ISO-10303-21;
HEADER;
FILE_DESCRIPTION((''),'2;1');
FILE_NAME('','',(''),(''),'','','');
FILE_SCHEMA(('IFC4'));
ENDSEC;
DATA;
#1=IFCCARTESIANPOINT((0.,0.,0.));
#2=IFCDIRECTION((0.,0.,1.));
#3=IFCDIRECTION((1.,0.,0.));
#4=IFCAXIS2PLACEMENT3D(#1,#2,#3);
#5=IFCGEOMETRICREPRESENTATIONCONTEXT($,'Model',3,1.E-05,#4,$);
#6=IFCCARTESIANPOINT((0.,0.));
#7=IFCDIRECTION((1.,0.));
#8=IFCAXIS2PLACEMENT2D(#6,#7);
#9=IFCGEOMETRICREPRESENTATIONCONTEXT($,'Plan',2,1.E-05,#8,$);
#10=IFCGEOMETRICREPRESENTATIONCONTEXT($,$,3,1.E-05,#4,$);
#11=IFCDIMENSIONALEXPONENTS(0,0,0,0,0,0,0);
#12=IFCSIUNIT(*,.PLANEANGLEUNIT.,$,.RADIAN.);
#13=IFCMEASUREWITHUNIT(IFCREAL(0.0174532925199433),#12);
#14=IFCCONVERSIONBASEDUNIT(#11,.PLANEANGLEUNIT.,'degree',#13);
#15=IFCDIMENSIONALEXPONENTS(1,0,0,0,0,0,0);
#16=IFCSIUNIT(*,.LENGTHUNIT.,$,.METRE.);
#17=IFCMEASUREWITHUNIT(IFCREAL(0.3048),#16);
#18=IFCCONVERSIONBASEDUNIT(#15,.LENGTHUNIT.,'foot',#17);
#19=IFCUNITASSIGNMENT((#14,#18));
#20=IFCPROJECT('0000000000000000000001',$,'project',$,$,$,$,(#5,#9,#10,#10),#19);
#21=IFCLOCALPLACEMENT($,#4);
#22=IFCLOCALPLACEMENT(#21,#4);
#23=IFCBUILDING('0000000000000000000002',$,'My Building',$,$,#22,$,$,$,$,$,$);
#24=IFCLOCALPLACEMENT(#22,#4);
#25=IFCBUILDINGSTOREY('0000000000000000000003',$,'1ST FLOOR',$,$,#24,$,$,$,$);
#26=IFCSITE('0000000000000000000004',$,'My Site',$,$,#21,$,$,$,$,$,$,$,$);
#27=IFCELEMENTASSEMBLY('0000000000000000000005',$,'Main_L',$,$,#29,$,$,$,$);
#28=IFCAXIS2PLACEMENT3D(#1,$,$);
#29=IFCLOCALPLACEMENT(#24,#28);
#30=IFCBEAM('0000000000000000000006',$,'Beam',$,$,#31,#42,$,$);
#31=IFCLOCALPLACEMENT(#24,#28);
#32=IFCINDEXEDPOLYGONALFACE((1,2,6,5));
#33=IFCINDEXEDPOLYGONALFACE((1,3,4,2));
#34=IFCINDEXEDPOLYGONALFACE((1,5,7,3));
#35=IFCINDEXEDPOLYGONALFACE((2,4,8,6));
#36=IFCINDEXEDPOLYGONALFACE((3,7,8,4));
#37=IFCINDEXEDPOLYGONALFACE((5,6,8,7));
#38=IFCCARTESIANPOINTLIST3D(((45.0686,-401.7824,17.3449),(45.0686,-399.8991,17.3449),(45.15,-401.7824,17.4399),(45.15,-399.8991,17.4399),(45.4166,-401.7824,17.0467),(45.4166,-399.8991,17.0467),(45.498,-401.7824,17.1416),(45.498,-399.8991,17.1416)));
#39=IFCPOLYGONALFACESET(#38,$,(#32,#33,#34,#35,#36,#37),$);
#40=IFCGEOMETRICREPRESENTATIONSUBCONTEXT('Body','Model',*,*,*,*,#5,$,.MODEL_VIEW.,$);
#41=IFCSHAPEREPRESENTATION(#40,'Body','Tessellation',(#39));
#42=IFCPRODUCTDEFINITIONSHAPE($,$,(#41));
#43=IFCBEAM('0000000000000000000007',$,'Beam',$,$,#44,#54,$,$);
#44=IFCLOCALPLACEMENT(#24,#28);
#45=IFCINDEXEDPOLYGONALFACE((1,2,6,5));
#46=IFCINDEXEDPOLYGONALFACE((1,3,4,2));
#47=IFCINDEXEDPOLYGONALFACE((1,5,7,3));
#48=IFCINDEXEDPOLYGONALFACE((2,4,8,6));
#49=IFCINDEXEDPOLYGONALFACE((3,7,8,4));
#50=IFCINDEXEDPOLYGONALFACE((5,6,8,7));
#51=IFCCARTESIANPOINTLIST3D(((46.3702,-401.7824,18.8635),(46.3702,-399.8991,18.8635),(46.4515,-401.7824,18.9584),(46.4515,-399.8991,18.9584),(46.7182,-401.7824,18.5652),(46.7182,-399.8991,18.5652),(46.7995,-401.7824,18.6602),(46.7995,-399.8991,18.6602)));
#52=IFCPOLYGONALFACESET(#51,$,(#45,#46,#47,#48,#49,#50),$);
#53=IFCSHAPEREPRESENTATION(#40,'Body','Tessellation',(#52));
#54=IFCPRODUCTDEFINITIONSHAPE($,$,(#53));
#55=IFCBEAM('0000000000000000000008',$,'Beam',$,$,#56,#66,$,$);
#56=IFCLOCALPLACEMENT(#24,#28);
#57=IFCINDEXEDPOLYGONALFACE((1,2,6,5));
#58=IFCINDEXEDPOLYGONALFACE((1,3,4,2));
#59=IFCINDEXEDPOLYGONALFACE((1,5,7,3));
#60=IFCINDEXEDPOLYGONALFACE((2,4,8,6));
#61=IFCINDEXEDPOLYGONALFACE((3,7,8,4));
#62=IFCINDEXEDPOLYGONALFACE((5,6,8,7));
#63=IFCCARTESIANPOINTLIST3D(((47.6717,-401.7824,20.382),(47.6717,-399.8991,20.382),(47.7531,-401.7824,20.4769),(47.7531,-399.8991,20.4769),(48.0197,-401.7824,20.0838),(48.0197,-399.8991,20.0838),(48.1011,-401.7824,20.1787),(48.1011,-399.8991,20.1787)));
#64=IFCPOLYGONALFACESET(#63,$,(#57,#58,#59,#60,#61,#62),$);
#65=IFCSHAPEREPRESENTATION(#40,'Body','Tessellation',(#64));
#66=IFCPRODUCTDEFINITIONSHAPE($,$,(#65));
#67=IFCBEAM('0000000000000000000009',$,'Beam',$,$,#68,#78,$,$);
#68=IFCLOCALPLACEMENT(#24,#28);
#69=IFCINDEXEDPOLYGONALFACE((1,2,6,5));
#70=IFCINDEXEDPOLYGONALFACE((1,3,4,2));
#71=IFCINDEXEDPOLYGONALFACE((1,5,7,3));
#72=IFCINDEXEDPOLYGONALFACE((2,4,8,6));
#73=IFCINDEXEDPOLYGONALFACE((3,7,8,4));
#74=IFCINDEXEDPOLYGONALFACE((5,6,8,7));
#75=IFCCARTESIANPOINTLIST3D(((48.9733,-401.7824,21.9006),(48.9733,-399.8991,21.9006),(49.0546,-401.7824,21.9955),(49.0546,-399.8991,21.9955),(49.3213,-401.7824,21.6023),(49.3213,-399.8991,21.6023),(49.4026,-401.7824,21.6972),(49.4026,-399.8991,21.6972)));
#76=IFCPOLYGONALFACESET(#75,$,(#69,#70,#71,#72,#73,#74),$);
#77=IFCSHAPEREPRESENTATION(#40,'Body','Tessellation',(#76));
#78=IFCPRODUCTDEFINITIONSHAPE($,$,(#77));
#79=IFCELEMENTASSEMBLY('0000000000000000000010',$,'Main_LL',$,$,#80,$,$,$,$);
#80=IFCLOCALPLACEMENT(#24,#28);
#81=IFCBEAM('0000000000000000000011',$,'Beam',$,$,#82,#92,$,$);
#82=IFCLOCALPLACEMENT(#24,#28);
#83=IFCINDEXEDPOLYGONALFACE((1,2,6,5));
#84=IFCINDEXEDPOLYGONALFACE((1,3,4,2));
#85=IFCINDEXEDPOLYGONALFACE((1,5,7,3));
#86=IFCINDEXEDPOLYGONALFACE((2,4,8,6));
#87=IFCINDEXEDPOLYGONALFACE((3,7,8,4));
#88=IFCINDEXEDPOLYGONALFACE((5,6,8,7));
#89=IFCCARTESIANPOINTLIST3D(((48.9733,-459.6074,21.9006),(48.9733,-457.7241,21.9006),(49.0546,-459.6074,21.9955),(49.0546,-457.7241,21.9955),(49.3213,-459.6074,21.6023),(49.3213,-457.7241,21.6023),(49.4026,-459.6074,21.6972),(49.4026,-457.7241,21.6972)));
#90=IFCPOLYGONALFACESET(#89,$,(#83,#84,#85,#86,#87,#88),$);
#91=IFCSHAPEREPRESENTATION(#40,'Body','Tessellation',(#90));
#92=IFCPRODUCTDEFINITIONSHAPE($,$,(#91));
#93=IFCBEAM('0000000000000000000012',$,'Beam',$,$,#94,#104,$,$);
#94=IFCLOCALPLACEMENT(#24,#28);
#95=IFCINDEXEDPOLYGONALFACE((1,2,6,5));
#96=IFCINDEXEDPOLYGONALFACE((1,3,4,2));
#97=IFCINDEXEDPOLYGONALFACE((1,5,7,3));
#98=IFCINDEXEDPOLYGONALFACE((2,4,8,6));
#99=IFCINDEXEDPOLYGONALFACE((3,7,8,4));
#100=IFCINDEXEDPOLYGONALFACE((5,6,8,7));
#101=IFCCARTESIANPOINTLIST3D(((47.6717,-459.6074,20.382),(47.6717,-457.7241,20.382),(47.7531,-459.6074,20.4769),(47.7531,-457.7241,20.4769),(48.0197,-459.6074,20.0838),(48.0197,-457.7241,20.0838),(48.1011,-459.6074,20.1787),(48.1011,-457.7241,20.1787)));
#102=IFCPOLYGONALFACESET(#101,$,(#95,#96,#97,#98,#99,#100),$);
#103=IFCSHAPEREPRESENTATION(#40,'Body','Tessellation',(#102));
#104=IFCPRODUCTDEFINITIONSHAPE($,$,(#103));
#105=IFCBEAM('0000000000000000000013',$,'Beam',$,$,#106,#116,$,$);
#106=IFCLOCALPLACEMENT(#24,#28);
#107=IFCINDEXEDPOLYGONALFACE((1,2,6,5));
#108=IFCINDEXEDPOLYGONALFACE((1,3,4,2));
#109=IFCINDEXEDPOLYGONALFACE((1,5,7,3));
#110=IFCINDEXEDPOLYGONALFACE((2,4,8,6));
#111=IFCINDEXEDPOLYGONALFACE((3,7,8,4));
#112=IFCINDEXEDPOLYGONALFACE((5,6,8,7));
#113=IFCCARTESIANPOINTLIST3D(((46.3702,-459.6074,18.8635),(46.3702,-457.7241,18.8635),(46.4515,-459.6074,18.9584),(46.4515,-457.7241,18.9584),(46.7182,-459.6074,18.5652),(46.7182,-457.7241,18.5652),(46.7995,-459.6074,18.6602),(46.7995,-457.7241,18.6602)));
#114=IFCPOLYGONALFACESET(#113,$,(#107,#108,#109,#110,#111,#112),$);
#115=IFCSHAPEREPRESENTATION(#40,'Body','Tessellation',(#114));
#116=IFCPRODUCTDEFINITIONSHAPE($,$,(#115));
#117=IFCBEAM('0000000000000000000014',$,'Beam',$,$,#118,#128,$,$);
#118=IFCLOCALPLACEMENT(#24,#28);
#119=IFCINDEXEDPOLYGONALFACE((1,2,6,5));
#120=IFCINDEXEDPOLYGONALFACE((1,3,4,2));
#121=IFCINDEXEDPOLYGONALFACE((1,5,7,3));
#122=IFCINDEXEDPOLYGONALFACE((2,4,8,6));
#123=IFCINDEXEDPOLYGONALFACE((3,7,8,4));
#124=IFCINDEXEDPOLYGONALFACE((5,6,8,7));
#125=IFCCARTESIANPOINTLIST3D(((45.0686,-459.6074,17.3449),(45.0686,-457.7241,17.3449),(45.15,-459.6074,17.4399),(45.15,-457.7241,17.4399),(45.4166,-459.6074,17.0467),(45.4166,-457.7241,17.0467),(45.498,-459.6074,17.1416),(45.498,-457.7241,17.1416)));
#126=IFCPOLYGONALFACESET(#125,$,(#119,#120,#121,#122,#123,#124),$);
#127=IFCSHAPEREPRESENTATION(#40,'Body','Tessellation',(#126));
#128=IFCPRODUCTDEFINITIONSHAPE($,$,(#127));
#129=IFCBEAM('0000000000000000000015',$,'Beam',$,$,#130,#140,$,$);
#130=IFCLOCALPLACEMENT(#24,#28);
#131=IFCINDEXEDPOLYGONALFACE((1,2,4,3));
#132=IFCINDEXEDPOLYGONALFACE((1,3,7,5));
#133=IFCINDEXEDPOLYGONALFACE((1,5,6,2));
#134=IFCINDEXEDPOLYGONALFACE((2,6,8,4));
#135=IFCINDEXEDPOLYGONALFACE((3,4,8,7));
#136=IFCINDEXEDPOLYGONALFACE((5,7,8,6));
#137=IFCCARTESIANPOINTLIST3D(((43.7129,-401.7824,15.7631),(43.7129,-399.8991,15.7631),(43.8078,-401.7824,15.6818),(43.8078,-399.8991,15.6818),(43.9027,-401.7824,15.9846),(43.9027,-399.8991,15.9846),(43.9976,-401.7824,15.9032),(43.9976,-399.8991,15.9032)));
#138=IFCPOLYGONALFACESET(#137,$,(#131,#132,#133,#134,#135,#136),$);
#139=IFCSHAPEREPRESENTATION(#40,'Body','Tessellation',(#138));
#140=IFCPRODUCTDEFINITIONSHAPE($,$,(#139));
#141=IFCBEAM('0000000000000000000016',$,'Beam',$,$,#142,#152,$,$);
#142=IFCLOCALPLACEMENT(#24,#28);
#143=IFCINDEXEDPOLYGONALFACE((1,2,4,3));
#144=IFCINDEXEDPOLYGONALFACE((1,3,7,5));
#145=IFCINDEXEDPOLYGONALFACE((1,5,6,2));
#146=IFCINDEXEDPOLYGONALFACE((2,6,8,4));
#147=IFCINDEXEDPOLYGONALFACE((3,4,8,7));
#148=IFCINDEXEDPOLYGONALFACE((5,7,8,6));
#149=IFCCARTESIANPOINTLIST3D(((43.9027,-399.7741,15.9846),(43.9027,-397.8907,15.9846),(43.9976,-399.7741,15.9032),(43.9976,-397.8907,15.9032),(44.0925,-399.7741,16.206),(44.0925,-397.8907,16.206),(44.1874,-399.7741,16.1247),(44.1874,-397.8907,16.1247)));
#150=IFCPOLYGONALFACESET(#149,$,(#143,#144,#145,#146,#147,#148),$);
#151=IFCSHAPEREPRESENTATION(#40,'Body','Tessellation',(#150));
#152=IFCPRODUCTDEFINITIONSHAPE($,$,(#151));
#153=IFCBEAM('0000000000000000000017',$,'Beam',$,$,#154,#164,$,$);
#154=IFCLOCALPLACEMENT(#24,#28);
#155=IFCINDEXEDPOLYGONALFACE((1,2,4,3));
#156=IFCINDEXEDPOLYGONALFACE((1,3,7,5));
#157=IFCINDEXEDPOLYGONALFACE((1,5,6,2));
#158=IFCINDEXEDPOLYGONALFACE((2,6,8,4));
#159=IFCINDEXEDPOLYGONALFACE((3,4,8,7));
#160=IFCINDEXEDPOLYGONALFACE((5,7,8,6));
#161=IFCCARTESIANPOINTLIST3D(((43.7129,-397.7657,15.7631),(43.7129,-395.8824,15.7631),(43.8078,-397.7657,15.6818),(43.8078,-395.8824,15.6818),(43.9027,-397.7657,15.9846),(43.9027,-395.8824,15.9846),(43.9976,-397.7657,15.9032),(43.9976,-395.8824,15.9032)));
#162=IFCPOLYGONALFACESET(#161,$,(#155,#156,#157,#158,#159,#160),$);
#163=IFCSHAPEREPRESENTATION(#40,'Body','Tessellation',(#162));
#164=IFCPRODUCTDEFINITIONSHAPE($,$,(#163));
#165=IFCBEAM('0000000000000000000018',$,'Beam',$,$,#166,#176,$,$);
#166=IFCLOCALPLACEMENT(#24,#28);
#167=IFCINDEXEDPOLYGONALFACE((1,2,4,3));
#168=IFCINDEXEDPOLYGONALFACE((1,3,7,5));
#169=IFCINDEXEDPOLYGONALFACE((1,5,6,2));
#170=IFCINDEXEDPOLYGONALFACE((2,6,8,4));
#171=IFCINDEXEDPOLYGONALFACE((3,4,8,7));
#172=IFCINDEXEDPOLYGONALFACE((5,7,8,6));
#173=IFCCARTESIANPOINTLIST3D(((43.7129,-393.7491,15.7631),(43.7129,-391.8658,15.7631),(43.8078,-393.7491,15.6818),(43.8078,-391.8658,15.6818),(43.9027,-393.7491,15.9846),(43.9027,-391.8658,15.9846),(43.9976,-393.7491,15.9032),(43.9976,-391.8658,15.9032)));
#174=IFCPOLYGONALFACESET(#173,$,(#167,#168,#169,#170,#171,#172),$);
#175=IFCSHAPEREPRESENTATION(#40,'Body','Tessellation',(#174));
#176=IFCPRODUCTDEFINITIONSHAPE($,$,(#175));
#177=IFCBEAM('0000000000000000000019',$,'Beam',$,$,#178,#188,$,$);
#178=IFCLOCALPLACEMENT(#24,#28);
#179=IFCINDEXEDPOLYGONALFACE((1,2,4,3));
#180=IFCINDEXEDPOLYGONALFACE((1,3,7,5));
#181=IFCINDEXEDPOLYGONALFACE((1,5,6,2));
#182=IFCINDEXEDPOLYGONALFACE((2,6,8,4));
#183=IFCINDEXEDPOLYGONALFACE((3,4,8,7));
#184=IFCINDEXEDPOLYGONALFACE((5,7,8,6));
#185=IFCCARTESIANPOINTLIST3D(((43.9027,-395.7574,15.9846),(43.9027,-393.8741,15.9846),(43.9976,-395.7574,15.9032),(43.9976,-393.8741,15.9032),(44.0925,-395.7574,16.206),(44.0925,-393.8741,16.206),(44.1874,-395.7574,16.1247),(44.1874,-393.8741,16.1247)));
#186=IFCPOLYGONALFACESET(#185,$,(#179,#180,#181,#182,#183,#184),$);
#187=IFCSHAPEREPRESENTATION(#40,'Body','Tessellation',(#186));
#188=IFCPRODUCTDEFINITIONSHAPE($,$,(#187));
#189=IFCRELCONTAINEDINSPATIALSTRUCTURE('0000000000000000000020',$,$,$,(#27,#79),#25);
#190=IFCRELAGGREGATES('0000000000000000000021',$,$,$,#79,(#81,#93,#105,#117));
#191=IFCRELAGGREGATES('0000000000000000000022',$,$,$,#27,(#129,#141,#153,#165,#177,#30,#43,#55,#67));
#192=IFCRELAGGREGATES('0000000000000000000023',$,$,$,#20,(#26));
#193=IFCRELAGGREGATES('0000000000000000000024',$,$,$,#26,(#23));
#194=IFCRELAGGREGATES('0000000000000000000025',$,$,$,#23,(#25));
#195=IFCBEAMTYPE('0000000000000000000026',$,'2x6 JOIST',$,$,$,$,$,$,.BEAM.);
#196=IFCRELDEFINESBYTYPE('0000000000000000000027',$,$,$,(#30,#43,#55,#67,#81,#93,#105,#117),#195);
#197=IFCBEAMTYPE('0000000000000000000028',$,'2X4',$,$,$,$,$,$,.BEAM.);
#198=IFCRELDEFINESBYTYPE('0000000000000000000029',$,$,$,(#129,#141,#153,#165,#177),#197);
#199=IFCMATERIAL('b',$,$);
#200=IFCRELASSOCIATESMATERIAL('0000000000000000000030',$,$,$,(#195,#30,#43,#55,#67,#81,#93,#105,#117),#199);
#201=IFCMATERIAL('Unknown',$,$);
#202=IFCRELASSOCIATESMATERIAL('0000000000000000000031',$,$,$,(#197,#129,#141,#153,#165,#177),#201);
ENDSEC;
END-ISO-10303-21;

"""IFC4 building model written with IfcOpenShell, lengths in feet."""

from ifc_helpers import new_model, entity, si_unit, converted_unit, frame, origin_with_axes, origin_2d_with_axis, place, context, subcontext, project, spatial, rectangle, extrude, material, material_profile, profile_set, profile_usage, type_object, element, aggregate, save


model = new_model("IFC4")

# Units and contexts
model_context = context("Model", 3, precision=1e-05, world=origin_with_axes())
plan_context = context("Plan", 2, precision=1e-05, world=origin_2d_with_axis())
context_of_model = context(None, 3, precision=1e-05, world=origin_with_axes())
body_context = subcontext(model_context, "Body", "Model", "MODEL_VIEW")
ifc_project = project(units=[converted_unit("PLANEANGLEUNIT", "degree", entity("IfcReal", 0.0174532925199433), si_unit("PLANEANGLEUNIT", "RADIAN"), dimensions=[0, 0, 0, 0, 0, 0, 0]), converted_unit("LENGTHUNIT", "foot", entity("IfcReal", 0.3048), si_unit("LENGTHUNIT", "METRE"), dimensions=[1, 0, 0, 0, 0, 0, 0])], contexts=[model_context, plan_context, context_of_model, context_of_model])

# Site, building, storey
site_placement = place(None, origin_with_axes())
site = spatial("IfcSite", under=ifc_project, at=site_placement, Name="My Site")
building_placement = place(site_placement, origin_with_axes())
building = spatial("IfcBuilding", under=site, at=building_placement, Name="My Building")
storey_placement = place(building_placement, origin_with_axes())
storey = spatial("IfcBuildingStorey", under=building, at=storey_placement, Name="1ST FLOOR")

# Element assemblies, beams
assembly_1_placement = place(storey_placement, origin_with_axes())
assembly_1 = element("IfcElementAssembly", 1, at=assembly_1_placement, inside=storey, Name="Main_L")
ifc_material_1 = material(Name="b")
ifc_material_profile_1 = material_profile(ifc_material_1, rectangle(XDim=0.125, YDim=0.4583))
ifc_profile_set_1 = profile_set([ifc_material_profile_1])
ifc_profile_usage_1 = profile_usage(ifc_profile_set_1, cardinal=8)
beam_type_1 = type_object("IfcBeamType", Name="2x6 JOIST", PredefinedType="BEAM", material=ifc_profile_set_1)
beam_1_placement = place(assembly_1_placement, frame((45.1093, -399.8991, 17.3924), z_axis=(0.0, -1.0, 0.0), x_axis=(0.650774, 0.0, 0.759271)))
beam_1 = element("IfcBeam", 2, at=beam_1_placement, type_object=beam_type_1, material=ifc_profile_usage_1, Name="Beam", context=body_context, shape_type="SweptSolid", body=[
    extrude(rectangle(XDim=0.125, YDim=0.4583), frame((0.0, -0.2291, 0.0)), (0.0, 0.0, 1.0), 1.8833),
])
ifc_profile_usage_2 = profile_usage(ifc_profile_set_1, cardinal=8)
beam_2_placement = place(assembly_1_placement, frame((46.4109, -399.8991, 18.9109), z_axis=(0.0, -1.0, 0.0), x_axis=(0.650774, 0.0, 0.759271)))
beam_2 = element("IfcBeam", 3, at=beam_2_placement, type_object=beam_type_1, material=ifc_profile_usage_2, Name="Beam", context=body_context, shape_type="SweptSolid", body=[
    extrude(rectangle(XDim=0.125, YDim=0.4583), frame((0.0, -0.2291, 0.0)), (0.0, 0.0, 1.0), 1.8833),
])
ifc_profile_usage_3 = profile_usage(ifc_profile_set_1, cardinal=8)
beam_3_placement = place(assembly_1_placement, frame((47.7124, -399.8991, 20.4295), z_axis=(0.0, -1.0, 0.0), x_axis=(0.650774, 0.0, 0.759271)))
beam_3 = element("IfcBeam", 4, at=beam_3_placement, type_object=beam_type_1, material=ifc_profile_usage_3, Name="Beam", context=body_context, shape_type="SweptSolid", body=[
    extrude(rectangle(XDim=0.125, YDim=0.4583), frame((0.0, -0.2291, 0.0)), (0.0, 0.0, 1.0), 1.8833),
])
ifc_profile_usage_4 = profile_usage(ifc_profile_set_1, cardinal=8)
beam_4_placement = place(assembly_1_placement, frame((49.014, -399.8991, 21.948), z_axis=(0.0, -1.0, 0.0), x_axis=(0.650774, 0.0, 0.759271)))
beam_4 = element("IfcBeam", 5, at=beam_4_placement, type_object=beam_type_1, material=ifc_profile_usage_4, Name="Beam", context=body_context, shape_type="SweptSolid", body=[
    extrude(rectangle(XDim=0.125, YDim=0.4583), frame((0.0, -0.2291, 0.0)), (0.0, 0.0, 1.0), 1.8833),
])
assembly_2_placement = place(storey_placement, origin_with_axes())
assembly_2 = element("IfcElementAssembly", 6, at=assembly_2_placement, inside=storey, Name="Main_LL")
ifc_profile_usage_5 = profile_usage(ifc_profile_set_1, cardinal=8)
beam_5_placement = place(assembly_2_placement, frame((49.014, -457.7241, 21.948), z_axis=(0.0, -1.0, 0.0), x_axis=(0.650774, 0.0, 0.759271)))
beam_5 = element("IfcBeam", 7, at=beam_5_placement, type_object=beam_type_1, material=ifc_profile_usage_5, Name="Beam", context=body_context, shape_type="SweptSolid", body=[
    extrude(rectangle(XDim=0.125, YDim=0.4583), frame((0.0, -0.2291, 0.0)), (0.0, 0.0, 1.0), 1.8833),
])
ifc_profile_usage_6 = profile_usage(ifc_profile_set_1, cardinal=8)
beam_6_placement = place(assembly_2_placement, frame((47.7124, -457.7241, 20.4295), z_axis=(0.0, -1.0, 0.0), x_axis=(0.650774, 0.0, 0.759271)))
beam_6 = element("IfcBeam", 8, at=beam_6_placement, type_object=beam_type_1, material=ifc_profile_usage_6, Name="Beam", context=body_context, shape_type="SweptSolid", body=[
    extrude(rectangle(XDim=0.125, YDim=0.4583), frame((0.0, -0.2291, 0.0)), (0.0, 0.0, 1.0), 1.8833),
])
ifc_profile_usage_7 = profile_usage(ifc_profile_set_1, cardinal=8)
beam_7_placement = place(assembly_2_placement, frame((46.4109, -457.7241, 18.9109), z_axis=(0.0, -1.0, 0.0), x_axis=(0.650774, 0.0, 0.759271)))
beam_7 = element("IfcBeam", 9, at=beam_7_placement, type_object=beam_type_1, material=ifc_profile_usage_7, Name="Beam", context=body_context, shape_type="SweptSolid", body=[
    extrude(rectangle(XDim=0.125, YDim=0.4583), frame((0.0, -0.2291, 0.0)), (0.0, 0.0, 1.0), 1.8833),
])
ifc_profile_usage_8 = profile_usage(ifc_profile_set_1, cardinal=8)
beam_8_placement = place(assembly_2_placement, frame((45.1093, -457.7241, 17.3924), z_axis=(0.0, -1.0, 0.0), x_axis=(0.650774, 0.0, 0.759271)))
beam_8 = element("IfcBeam", 10, at=beam_8_placement, type_object=beam_type_1, material=ifc_profile_usage_8, Name="Beam", context=body_context, shape_type="SweptSolid", body=[
    extrude(rectangle(XDim=0.125, YDim=0.4583), frame((0.0, -0.2291, 0.0)), (0.0, 0.0, 1.0), 1.8833),
])

# Beams
ifc_material_2 = material(Name="Unknown")
ifc_material_profile_2 = material_profile(ifc_material_2, rectangle(XDim=0.125, YDim=0.2917))
ifc_profile_set_2 = profile_set([ifc_material_profile_2])
ifc_profile_usage_9 = profile_usage(ifc_profile_set_2, cardinal=5)
beam_type_2 = type_object("IfcBeamType", Name="2X4", PredefinedType="BEAM", material=ifc_profile_set_2)
beam_9_placement = place(assembly_1_placement, frame((43.8552, -399.8991, 15.8332), z_axis=(0.0, -1.0, 0.0), x_axis=(-0.759271, 0.0, 0.650774)))
beam_9 = element("IfcBeam", 11, at=beam_9_placement, type_object=beam_type_2, material=ifc_profile_usage_9, Name="Beam", context=body_context, shape_type="SweptSolid", body=[
    extrude(rectangle(XDim=0.125, YDim=0.2917), origin_with_axes(), (0.0, 0.0, 1.0), 1.8833),
])
ifc_profile_usage_10 = profile_usage(ifc_profile_set_2, cardinal=5)
beam_10_placement = place(assembly_1_placement, frame((44.045, -397.8907, 16.0546), z_axis=(0.0, -1.0, 0.0), x_axis=(-0.759271, 0.0, 0.650774)))
beam_10 = element("IfcBeam", 12, at=beam_10_placement, type_object=beam_type_2, material=ifc_profile_usage_10, Name="Beam", context=body_context, shape_type="SweptSolid", body=[
    extrude(rectangle(XDim=0.125, YDim=0.2917), origin_with_axes(), (0.0, 0.0, 1.0), 1.8833),
])
ifc_profile_usage_11 = profile_usage(ifc_profile_set_2, cardinal=5)
beam_11_placement = place(assembly_1_placement, frame((43.8552, -395.8824, 15.8332), z_axis=(0.0, -1.0, 0.0), x_axis=(-0.759271, 0.0, 0.650774)))
beam_11 = element("IfcBeam", 13, at=beam_11_placement, type_object=beam_type_2, material=ifc_profile_usage_11, Name="Beam", context=body_context, shape_type="SweptSolid", body=[
    extrude(rectangle(XDim=0.125, YDim=0.2917), origin_with_axes(), (0.0, 0.0, 1.0), 1.8833),
])
ifc_profile_usage_12 = profile_usage(ifc_profile_set_2, cardinal=5)
beam_12_placement = place(assembly_1_placement, frame((43.8552, -391.8658, 15.8332), z_axis=(0.0, -1.0, 0.0), x_axis=(-0.759271, 0.0, 0.650774)))
beam_12 = element("IfcBeam", 14, at=beam_12_placement, type_object=beam_type_2, material=ifc_profile_usage_12, Name="Beam", context=body_context, shape_type="SweptSolid", body=[
    extrude(rectangle(XDim=0.125, YDim=0.2917), origin_with_axes(), (0.0, 0.0, 1.0), 1.8833),
])
ifc_profile_usage_13 = profile_usage(ifc_profile_set_2, cardinal=5)
beam_13_placement = place(assembly_1_placement, frame((44.045, -393.8741, 16.0546), z_axis=(0.0, -1.0, 0.0), x_axis=(-0.759271, 0.0, 0.650774)))
beam_13 = element("IfcBeam", 15, at=beam_13_placement, type_object=beam_type_2, material=ifc_profile_usage_13, Name="Beam", context=body_context, shape_type="SweptSolid", body=[
    extrude(rectangle(XDim=0.125, YDim=0.2917), origin_with_axes(), (0.0, 0.0, 1.0), 1.8833),
])
aggregate(assembly_2, [beam_5, beam_6, beam_7, beam_8])

aggregate(assembly_1, [beam_9, beam_10, beam_11, beam_12, beam_13, beam_1, beam_2, beam_3, beam_4])

save(model, "model.ifc")
